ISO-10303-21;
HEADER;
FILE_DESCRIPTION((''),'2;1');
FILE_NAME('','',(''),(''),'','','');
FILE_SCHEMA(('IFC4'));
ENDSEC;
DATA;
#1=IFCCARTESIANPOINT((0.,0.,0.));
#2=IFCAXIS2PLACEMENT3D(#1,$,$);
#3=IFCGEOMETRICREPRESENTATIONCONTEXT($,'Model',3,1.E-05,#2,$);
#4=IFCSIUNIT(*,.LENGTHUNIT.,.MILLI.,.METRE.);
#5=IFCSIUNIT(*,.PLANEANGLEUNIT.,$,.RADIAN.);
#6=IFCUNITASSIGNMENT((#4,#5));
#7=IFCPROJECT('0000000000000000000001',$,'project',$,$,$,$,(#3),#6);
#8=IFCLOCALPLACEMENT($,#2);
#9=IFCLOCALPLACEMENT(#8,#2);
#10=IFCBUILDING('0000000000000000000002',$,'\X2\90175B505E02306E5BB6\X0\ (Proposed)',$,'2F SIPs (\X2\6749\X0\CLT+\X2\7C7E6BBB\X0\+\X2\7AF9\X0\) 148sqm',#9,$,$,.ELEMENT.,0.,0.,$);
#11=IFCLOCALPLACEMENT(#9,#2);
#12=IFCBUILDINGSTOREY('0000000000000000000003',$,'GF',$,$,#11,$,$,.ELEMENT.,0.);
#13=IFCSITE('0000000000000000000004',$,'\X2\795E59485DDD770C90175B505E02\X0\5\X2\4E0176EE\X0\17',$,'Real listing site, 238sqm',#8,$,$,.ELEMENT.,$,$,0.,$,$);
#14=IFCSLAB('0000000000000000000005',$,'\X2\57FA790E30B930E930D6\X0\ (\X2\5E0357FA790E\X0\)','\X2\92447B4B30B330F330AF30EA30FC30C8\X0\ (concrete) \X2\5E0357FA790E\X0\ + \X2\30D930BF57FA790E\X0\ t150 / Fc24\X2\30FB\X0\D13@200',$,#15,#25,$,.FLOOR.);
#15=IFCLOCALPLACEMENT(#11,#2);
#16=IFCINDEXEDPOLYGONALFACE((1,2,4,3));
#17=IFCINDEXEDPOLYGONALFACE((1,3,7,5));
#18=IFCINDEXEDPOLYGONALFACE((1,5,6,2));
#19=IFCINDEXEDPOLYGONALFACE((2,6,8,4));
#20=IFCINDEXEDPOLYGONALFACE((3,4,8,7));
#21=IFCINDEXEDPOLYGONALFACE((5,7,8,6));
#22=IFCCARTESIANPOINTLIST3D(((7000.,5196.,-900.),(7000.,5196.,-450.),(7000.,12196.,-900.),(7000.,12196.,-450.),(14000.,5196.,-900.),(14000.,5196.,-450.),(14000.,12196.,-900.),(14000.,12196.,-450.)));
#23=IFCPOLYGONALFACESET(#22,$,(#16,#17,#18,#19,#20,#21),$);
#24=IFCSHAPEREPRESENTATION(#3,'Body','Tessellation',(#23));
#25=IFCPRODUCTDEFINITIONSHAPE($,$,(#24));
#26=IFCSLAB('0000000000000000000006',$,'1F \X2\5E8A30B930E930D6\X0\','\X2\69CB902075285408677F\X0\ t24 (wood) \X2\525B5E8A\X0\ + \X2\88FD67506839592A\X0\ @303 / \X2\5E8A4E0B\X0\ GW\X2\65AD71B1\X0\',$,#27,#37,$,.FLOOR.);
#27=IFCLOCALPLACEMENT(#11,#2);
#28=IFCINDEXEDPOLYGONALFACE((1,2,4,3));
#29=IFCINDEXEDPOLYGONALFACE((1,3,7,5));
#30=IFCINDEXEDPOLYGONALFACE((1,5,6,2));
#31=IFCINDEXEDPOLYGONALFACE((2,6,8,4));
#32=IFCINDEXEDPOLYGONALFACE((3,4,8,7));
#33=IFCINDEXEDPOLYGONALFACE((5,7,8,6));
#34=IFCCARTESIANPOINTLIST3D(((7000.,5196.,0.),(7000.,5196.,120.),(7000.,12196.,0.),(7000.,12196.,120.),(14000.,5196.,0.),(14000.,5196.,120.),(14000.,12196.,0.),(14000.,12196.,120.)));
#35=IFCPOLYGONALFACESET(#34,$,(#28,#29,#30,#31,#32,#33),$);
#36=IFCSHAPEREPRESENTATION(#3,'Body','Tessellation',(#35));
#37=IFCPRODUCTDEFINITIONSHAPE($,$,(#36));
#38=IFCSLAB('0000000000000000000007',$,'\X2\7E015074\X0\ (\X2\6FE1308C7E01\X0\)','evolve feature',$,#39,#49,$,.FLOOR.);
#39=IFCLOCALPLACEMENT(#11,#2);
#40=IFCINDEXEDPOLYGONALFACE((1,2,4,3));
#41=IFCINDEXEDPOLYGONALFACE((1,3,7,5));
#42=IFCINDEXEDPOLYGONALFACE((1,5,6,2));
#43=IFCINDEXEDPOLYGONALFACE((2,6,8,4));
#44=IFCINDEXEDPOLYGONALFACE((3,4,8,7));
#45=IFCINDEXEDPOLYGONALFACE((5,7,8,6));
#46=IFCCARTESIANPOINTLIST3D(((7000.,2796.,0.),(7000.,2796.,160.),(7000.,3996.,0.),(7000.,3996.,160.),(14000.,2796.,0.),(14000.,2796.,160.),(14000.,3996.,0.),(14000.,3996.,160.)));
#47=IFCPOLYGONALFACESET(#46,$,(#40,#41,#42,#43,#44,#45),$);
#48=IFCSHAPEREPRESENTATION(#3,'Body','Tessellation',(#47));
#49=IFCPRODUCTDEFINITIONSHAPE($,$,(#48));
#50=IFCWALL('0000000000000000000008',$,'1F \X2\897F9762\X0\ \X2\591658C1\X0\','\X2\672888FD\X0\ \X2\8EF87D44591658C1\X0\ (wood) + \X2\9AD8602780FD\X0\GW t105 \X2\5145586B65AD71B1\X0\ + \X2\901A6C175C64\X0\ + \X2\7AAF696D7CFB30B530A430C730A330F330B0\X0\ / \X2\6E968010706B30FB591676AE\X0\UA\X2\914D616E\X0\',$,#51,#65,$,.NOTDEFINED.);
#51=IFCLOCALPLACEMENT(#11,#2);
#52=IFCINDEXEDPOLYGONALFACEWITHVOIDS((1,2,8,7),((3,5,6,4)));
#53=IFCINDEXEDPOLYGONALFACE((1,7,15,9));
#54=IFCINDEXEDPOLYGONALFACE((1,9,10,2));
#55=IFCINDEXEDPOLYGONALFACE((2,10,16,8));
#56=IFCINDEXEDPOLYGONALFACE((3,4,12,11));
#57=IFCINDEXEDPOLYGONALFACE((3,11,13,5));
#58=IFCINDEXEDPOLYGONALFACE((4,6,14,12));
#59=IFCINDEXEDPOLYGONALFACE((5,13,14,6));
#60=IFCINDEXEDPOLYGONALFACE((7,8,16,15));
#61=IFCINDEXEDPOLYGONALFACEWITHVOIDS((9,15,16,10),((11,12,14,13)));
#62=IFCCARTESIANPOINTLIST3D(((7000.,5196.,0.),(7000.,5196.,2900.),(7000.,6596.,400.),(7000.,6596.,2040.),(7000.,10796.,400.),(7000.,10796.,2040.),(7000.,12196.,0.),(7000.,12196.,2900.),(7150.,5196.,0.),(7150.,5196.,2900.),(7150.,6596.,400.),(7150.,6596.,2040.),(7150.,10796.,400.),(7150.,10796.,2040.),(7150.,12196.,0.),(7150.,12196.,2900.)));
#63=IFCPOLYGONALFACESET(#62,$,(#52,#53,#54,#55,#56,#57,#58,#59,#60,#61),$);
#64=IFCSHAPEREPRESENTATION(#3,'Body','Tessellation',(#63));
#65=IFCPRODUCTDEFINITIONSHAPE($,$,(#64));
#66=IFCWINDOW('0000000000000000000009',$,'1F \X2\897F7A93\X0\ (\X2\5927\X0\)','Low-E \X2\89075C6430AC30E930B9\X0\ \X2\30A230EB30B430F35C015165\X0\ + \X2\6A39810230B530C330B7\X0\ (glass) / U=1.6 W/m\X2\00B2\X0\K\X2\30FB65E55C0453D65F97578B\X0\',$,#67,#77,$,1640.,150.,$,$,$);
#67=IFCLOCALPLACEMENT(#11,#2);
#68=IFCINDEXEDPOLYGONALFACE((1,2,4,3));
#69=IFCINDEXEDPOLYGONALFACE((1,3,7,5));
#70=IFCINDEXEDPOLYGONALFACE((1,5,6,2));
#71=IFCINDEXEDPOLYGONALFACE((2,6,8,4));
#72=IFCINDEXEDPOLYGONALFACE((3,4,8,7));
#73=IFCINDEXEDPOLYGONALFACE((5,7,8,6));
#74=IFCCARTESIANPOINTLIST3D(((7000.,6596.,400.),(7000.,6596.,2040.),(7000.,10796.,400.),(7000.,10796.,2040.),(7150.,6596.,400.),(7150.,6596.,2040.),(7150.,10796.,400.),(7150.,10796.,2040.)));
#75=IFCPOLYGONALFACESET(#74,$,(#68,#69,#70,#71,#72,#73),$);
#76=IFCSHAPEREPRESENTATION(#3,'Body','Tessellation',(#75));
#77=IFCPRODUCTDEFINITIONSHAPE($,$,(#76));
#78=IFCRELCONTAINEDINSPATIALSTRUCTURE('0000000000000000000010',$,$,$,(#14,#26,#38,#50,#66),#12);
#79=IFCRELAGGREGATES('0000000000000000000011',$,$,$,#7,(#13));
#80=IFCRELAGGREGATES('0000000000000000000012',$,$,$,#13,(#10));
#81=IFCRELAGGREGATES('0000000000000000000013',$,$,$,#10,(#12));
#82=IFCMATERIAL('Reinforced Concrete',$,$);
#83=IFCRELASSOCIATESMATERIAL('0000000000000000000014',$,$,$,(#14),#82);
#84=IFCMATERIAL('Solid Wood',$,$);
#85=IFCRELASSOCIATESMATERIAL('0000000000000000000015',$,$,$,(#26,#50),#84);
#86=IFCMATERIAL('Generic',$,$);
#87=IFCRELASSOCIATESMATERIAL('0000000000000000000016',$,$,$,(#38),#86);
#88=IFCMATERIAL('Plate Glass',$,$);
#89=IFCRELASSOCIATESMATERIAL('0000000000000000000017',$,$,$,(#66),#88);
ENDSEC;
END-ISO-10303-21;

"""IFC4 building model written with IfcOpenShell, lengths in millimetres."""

from ifc_helpers import new_model, si_unit, frame, frame_2d, origin, place, context, project, spatial, rectangle, extrude, material, element, fill, save


model = new_model("IFC4")

# Units and contexts
model_context = context("Model", 3, precision=1e-05, world=origin())
ifc_project = project(units=[si_unit("LENGTHUNIT", "METRE", prefix="MILLI"), si_unit("PLANEANGLEUNIT", "RADIAN")], contexts=[model_context])

# Site, building, storey
site_placement = place(None, origin())
site = spatial("IfcSite", under=ifc_project, at=site_placement, Name="神奈川県逗子市5丁目17", ObjectType="Real listing site, 238sqm", CompositionType="ELEMENT", RefElevation=0.0)
building_placement = place(site_placement, origin())
building = spatial("IfcBuilding", under=site, at=building_placement, Name="逗子市の家 (Proposed)", ObjectType="2F SIPs (杉CLT+籾殻+竹) 148sqm", CompositionType="ELEMENT", ElevationOfRefHeight=0.0, ElevationOfTerrain=0.0)
storey_placement = place(building_placement, origin())
storey = spatial("IfcBuildingStorey", under=building, at=storey_placement, Name="GF", CompositionType="ELEMENT", Elevation=0.0)

# Slabs
ifc_material_1 = material(Name="Reinforced Concrete")
slab_1_placement = place(storey_placement, frame((3500.0, 2598.0, -450.0)))
element("IfcSlab", 1, at=slab_1_placement, inside=storey, material=ifc_material_1, Name="基礎スラブ (布基礎)", Description="鉄筋コンクリート (concrete) 布基礎 + ベタ基礎 t150 / Fc24・D13@200", PredefinedType="FLOOR", context=model_context, shape_type="SweptSolid", body=[
    extrude(rectangle(XDim=7000.0, YDim=7000.0, at=frame_2d((3500.0, 3500.0))), frame((3500.0, 2598.0, -450.0)), (0.0, 0.0, 1.0), 450.0),
])
ifc_material_2 = material(Name="Solid Wood")
slab_2_placement = place(storey_placement, frame((3500.0, 2598.0, 0.0)))
element("IfcSlab", 2, at=slab_2_placement, inside=storey, material=ifc_material_2, Name="1F 床スラブ", Description="構造用合板 t24 (wood) 剛床 + 製材根太 @303 / 床下 GW断熱", PredefinedType="FLOOR", context=model_context, shape_type="SweptSolid", body=[
    extrude(rectangle(XDim=7000.0, YDim=7000.0, at=frame_2d((3500.0, 3500.0))), frame((3500.0, 2598.0, 0.0)), (0.0, 0.0, 1.0), 120.0),
])
ifc_material_3 = material(Name="Generic")
slab_3_placement = place(storey_placement, frame((3500.0, 1398.0, 0.0)))
element("IfcSlab", 3, at=slab_3_placement, inside=storey, material=ifc_material_3, Name="縁側 (濡れ縁)", Description="evolve feature", PredefinedType="FLOOR", context=model_context, shape_type="SweptSolid", body=[
    extrude(rectangle(XDim=7000.0, YDim=1200.0, at=frame_2d((3500.0, 600.0))), frame((3500.0, 1398.0, 0.0)), (0.0, 0.0, 1.0), 160.0),
])

# Shared definitions
ifc_material_4 = material(Name="Plate Glass")

# Wall, opening, window
wall_1_placement = place(storey_placement, frame((3500.0, 2598.0, 0.0)))
wall_1 = element("IfcWall", 4, at=wall_1_placement, inside=storey, material=ifc_material_2, Name="1F 西面 外壁", Description="木製 軸組外壁 (wood) + 高性能GW t105 充填断熱 + 通気層 + 窯業系サイディング / 準耐火・外皮UA配慮", PredefinedType="NOTDEFINED", context=model_context, shape_type="SweptSolid", body=[
    extrude(rectangle(XDim=150.0, YDim=7000.0, at=frame_2d((75.0, 3500.0))), frame((3500.0, 2598.0, 0.0)), (0.0, 0.0, 1.0), 2900.0),
])
opening_1_placement = place(storey_placement, frame((3500.0, 3298.0, 200.0)))
opening_1 = element("IfcOpeningElement", 5, at=opening_1_placement, cuts=wall_1, PredefinedType="NOTDEFINED", context=model_context, shape_type="SweptSolid", body=[
    extrude(rectangle(XDim=150.0, YDim=4200.0, at=frame_2d((75.0, 2100.0))), frame((3500.0, 3298.0, 200.0)), (0.0, 0.0, 1.0), 1640.0),
])
window_1_placement = place(storey_placement, frame((3500.0, 3298.0, 200.0)))
window_1 = element("IfcWindow", 6, at=window_1_placement, inside=storey, material=ifc_material_4, Name="1F 西窓 (大)", Description="Low-E 複層ガラス アルゴン封入 + 樹脂サッシ (glass) / U=1.6 W/m²K・日射取得型", OverallHeight=1640.0, OverallWidth=150.0, context=model_context, shape_type="SweptSolid", body=[
    extrude(rectangle(XDim=150.0, YDim=4200.0, at=frame_2d((75.0, 2100.0))), frame((3500.0, 3298.0, 200.0)), (0.0, 0.0, 1.0), 1640.0),
])
fill(opening_1, window_1)

save(model, "model.ifc")
